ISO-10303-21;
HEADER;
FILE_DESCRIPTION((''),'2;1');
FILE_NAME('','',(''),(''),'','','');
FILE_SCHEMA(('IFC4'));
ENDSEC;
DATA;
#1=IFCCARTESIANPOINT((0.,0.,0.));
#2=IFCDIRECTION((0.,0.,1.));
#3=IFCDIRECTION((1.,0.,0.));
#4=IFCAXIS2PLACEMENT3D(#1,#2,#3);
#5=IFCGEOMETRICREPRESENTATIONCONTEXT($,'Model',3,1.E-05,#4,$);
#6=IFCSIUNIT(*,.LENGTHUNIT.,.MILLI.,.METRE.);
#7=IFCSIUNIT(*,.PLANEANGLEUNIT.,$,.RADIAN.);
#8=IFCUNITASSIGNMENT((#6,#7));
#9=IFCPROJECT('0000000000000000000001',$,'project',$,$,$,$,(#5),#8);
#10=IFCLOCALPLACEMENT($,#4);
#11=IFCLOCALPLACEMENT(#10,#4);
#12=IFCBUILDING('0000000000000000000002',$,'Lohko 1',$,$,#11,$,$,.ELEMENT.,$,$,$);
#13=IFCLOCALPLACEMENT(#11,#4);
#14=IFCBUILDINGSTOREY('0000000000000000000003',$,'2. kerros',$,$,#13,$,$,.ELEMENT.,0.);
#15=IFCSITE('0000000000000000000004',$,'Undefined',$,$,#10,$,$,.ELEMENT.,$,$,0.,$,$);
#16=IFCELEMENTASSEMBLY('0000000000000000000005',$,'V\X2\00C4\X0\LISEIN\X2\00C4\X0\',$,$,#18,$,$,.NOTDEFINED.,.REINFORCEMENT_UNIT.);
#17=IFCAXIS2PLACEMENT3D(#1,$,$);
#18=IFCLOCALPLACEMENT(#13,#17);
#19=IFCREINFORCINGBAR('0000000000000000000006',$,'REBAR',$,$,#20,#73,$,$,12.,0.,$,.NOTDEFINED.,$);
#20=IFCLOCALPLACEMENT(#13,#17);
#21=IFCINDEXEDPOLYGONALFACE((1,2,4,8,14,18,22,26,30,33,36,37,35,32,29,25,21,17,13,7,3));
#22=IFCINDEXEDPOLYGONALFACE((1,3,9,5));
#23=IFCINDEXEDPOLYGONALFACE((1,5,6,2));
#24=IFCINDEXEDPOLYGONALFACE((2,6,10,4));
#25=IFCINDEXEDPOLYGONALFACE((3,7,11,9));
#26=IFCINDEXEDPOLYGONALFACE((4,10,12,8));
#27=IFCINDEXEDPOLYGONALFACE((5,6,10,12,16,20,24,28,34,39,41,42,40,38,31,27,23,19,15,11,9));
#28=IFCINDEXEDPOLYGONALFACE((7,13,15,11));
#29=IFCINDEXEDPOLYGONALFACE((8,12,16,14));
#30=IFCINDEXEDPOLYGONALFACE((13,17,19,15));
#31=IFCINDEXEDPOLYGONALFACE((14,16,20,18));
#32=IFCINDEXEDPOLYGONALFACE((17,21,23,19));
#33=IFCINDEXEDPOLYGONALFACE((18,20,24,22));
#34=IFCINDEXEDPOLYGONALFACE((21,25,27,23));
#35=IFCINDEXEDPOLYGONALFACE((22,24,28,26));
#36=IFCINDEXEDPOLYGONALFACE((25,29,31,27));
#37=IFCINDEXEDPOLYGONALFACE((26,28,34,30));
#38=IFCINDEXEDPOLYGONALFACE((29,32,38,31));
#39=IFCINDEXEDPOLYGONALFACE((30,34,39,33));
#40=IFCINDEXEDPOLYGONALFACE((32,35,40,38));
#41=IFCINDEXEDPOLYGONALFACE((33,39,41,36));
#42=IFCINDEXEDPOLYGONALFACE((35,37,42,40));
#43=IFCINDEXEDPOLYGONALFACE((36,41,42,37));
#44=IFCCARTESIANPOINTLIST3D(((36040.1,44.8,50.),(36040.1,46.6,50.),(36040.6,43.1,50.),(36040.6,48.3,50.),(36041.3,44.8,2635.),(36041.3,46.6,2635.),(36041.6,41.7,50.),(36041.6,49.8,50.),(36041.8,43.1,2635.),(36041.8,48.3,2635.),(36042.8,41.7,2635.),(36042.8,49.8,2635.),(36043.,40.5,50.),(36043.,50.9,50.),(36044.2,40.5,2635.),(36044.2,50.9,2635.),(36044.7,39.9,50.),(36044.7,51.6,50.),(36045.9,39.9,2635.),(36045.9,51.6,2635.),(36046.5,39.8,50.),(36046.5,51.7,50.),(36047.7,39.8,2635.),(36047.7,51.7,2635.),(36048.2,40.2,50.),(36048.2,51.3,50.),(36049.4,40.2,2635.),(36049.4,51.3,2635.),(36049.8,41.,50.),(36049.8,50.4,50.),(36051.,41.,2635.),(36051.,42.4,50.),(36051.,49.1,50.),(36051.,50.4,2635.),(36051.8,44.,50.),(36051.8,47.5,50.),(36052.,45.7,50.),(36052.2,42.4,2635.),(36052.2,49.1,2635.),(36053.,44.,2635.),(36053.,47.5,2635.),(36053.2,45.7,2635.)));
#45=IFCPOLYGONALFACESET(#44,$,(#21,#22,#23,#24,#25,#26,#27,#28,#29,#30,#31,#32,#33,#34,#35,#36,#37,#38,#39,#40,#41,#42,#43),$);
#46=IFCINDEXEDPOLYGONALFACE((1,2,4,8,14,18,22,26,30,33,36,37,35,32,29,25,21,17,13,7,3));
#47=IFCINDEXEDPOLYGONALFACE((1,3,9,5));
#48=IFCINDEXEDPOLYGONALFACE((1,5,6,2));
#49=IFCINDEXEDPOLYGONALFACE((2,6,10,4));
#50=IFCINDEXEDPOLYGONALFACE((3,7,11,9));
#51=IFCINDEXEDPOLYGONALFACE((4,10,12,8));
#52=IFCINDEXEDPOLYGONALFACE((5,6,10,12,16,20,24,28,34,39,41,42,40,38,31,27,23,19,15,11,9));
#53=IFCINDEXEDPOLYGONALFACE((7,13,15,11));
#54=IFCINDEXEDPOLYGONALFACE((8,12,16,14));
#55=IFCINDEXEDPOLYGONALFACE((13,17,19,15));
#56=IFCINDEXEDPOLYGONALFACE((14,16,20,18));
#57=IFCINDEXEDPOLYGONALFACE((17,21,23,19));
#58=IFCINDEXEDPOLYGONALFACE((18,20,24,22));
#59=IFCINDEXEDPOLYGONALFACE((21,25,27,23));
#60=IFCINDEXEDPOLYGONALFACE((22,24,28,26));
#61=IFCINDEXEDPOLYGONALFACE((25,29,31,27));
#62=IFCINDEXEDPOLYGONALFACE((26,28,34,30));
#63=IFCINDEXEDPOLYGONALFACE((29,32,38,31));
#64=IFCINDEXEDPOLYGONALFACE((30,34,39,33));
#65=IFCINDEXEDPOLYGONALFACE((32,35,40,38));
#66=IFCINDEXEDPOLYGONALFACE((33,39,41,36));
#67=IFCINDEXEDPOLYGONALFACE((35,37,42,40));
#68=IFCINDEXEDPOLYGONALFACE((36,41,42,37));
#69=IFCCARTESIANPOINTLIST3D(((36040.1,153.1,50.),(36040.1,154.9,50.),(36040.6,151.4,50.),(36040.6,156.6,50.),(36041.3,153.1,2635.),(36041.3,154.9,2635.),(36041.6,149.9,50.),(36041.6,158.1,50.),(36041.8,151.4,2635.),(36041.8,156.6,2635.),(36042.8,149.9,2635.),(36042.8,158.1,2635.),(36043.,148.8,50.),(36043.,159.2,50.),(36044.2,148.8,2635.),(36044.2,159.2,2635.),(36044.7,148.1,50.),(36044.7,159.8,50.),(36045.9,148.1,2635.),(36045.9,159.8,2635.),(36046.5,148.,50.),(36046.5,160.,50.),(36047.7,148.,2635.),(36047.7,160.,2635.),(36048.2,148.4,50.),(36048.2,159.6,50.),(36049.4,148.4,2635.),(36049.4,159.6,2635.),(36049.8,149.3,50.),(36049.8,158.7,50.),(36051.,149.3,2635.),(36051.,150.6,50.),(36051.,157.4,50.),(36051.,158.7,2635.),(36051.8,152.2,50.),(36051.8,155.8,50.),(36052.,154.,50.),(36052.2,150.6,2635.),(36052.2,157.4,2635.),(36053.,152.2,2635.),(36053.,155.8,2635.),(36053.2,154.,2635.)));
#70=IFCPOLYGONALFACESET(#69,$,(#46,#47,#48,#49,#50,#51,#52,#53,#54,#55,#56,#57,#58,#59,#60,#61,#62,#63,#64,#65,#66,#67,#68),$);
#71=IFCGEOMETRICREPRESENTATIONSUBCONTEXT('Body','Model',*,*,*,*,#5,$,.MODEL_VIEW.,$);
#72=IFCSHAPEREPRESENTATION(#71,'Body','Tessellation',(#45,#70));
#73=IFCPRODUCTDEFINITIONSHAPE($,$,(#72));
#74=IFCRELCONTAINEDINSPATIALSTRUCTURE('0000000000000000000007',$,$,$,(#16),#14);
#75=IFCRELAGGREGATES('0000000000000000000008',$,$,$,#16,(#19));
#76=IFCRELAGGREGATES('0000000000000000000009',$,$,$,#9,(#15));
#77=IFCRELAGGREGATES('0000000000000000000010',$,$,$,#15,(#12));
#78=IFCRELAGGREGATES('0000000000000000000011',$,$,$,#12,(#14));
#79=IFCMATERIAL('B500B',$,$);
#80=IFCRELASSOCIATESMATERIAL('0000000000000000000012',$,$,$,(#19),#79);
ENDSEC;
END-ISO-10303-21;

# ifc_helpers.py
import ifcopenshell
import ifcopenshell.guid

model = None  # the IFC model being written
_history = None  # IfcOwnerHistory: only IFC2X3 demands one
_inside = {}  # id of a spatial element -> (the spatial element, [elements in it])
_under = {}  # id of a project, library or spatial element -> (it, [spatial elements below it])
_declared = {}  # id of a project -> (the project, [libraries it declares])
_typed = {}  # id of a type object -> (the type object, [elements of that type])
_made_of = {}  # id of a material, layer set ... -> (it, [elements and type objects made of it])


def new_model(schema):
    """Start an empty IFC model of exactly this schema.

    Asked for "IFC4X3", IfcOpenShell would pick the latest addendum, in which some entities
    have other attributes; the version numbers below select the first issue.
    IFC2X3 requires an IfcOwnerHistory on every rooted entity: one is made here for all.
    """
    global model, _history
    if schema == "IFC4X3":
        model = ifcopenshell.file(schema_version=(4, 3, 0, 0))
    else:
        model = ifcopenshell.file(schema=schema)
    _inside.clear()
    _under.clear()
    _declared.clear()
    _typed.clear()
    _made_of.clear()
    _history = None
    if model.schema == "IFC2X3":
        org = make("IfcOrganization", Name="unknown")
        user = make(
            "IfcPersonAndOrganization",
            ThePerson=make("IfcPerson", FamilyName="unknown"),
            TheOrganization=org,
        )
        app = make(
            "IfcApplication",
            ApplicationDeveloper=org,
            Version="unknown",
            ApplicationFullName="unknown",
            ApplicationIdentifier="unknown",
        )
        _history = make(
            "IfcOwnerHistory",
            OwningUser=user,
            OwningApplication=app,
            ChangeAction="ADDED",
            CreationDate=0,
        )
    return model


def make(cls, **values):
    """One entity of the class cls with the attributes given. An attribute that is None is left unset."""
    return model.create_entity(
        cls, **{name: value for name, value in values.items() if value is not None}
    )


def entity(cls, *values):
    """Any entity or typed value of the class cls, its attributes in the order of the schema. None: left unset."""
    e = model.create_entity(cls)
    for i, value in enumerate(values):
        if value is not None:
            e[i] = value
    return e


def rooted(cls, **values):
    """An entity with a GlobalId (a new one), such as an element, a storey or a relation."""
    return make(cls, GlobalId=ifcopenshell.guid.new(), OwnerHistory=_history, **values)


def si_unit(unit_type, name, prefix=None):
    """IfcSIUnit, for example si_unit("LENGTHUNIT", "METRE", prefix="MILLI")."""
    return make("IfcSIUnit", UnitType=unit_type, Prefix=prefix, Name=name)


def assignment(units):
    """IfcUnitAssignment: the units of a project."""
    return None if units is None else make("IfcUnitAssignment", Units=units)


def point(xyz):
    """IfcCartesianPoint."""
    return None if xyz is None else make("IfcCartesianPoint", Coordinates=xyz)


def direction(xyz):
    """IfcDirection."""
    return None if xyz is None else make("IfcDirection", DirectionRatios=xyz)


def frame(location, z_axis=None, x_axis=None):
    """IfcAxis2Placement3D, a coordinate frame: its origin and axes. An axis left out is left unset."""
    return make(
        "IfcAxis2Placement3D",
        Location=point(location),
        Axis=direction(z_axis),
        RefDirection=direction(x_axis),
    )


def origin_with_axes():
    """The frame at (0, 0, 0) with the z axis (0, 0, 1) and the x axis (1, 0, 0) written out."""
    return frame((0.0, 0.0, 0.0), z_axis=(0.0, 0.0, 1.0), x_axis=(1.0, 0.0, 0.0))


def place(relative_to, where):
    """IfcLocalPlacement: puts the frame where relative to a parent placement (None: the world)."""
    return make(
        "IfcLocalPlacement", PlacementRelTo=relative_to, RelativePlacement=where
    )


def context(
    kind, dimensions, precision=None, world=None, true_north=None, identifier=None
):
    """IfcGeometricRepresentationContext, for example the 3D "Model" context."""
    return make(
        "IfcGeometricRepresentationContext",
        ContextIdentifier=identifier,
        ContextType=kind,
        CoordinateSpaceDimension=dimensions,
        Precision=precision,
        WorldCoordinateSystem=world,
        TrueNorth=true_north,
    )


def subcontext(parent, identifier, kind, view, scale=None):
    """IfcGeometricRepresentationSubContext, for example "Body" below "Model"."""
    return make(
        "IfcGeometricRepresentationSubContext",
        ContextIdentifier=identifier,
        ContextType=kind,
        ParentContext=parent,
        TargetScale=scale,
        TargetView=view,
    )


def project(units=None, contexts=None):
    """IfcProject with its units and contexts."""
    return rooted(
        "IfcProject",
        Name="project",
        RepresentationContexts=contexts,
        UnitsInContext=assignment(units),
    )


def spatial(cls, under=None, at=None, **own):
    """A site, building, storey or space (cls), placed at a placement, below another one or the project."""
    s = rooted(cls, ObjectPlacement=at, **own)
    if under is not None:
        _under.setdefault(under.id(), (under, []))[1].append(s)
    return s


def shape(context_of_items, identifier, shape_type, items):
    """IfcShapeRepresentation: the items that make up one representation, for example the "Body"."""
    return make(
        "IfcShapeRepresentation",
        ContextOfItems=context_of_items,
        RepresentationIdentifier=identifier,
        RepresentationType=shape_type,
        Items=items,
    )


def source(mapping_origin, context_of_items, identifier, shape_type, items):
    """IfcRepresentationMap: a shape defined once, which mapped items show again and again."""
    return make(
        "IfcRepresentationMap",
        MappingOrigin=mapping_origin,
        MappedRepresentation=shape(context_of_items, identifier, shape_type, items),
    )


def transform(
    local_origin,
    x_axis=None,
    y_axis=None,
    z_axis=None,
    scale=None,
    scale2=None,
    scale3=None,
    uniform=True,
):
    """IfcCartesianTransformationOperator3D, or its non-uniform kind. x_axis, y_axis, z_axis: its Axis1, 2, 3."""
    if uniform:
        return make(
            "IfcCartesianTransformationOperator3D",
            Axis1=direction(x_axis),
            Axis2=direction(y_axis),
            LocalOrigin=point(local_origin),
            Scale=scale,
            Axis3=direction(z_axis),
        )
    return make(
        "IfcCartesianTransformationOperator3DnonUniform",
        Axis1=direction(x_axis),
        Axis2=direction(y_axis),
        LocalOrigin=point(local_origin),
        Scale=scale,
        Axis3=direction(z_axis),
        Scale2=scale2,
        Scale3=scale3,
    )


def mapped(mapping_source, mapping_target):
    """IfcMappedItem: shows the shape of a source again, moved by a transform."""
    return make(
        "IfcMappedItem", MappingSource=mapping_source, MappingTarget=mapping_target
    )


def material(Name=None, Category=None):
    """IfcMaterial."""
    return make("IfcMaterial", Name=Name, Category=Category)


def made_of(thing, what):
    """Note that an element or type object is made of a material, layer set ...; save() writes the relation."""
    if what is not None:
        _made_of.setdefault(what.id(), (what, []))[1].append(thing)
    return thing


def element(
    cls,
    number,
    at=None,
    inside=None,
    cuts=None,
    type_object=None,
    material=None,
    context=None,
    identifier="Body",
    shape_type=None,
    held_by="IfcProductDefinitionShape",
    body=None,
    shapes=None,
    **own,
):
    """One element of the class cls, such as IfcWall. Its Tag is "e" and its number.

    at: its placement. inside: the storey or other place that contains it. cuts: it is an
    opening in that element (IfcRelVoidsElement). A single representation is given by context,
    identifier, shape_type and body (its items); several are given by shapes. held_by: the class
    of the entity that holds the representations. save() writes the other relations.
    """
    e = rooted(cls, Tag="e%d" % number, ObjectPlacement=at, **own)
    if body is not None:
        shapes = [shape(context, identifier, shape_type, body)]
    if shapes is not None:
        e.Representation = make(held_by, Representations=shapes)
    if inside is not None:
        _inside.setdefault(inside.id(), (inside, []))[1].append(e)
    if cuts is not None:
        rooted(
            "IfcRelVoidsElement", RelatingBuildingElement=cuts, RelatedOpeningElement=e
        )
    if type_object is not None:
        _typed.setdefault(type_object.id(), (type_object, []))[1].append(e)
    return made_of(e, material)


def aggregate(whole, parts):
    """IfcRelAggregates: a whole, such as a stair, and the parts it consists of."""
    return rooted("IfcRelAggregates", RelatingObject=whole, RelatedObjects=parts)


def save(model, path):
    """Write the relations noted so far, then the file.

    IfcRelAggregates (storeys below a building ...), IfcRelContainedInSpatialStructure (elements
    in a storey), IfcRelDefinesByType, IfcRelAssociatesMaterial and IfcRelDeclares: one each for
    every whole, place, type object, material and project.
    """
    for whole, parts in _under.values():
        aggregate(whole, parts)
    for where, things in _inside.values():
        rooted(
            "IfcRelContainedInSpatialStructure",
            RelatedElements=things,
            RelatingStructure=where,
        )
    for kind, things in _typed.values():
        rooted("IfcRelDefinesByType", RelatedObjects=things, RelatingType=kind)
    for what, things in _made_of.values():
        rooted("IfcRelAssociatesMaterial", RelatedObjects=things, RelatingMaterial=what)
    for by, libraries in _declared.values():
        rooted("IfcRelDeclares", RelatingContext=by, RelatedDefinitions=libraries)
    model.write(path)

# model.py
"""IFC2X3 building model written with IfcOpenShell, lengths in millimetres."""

from ifc_helpers import new_model, entity, si_unit, frame, origin_with_axes, place, context, subcontext, project, spatial, source, transform, mapped, material, element, aggregate, save


model = new_model("IFC2X3")

# Units and contexts
model_context = context("Model", 3, precision=1e-05, world=origin_with_axes())
body_context = subcontext(model_context, "Body", "Model", "MODEL_VIEW")
ifc_project = project(units=[si_unit("LENGTHUNIT", "METRE", prefix="MILLI"), si_unit("PLANEANGLEUNIT", "RADIAN")], contexts=[model_context])

# Site, building, storey
site_placement = place(None, origin_with_axes())
site = spatial("IfcSite", under=ifc_project, at=site_placement, Name="Undefined", CompositionType="ELEMENT", RefElevation=0.0)
building_placement = place(site_placement, origin_with_axes())
building = spatial("IfcBuilding", under=site, at=building_placement, Name="Lohko 1", CompositionType="ELEMENT")
storey_placement = place(building_placement, origin_with_axes())
storey = spatial("IfcBuildingStorey", under=building, at=storey_placement, Name="2. kerros", CompositionType="ELEMENT", Elevation=0.0)

# Element assembly, reinforcing bar
assembly_placement = place(storey_placement, origin_with_axes())
assembly = element("IfcElementAssembly", 1, at=assembly_placement, inside=storey, Name="VÄLISEINÄ", AssemblyPlace="NOTDEFINED", PredefinedType="REINFORCEMENT_UNIT")
ifc_material = material(Name="B500B")
shared_shape_1 = source(origin_with_axes(), body_context, "Body", "AdvancedSweptSolid", [
    entity("IfcSweptDiskSolid", entity("IfcTrimmedCurve", entity("IfcLine", entity("IfcCartesianPoint", [0.0, 0.0, 0.0]), entity("IfcVector", entity("IfcDirection", [1.0, 0.0, 0.0]), 1.0)), [entity("IfcParameterValue", 0.0)], [entity("IfcParameterValue", 2585.000291)], True, "PARAMETER"), 6.0, None, 0.0, 2585.0),
])
shared_shape_2 = source(origin_with_axes(), body_context, "Body", "AdvancedSweptSolid", [
    entity("IfcSweptDiskSolid", entity("IfcTrimmedCurve", entity("IfcLine", entity("IfcCartesianPoint", [0.0, 0.0, 0.0]), entity("IfcVector", entity("IfcDirection", [1.0, 0.0, 0.0]), 1.0)), [entity("IfcParameterValue", 0.0)], [entity("IfcParameterValue", 2585.000291)], True, "PARAMETER"), 6.0, None, 0.0, 2585.0),
])
reinforcing_bar_1_placement = place(assembly_placement, frame((36001.3, -0.3, 2685.0), z_axis=(1.0, -0.000007, -0.000466), x_axis=(-0.000466, 0.0, -1.0)))
reinforcing_bar_1 = element("IfcReinforcingBar", 2, at=reinforcing_bar_1_placement, material=ifc_material, Name="REBAR", BarRole="NOTDEFINED", CrossSectionArea=0.0, NominalDiameter=12.0, context=body_context, shape_type="MappedRepresentation", body=[
    mapped(shared_shape_1, transform((50.0, 46.0, 46.0))),
    mapped(shared_shape_2, transform((50.0, 154.3, 46.0))),
])
aggregate(assembly, [reinforcing_bar_1])

save(model, "model.ifc")
